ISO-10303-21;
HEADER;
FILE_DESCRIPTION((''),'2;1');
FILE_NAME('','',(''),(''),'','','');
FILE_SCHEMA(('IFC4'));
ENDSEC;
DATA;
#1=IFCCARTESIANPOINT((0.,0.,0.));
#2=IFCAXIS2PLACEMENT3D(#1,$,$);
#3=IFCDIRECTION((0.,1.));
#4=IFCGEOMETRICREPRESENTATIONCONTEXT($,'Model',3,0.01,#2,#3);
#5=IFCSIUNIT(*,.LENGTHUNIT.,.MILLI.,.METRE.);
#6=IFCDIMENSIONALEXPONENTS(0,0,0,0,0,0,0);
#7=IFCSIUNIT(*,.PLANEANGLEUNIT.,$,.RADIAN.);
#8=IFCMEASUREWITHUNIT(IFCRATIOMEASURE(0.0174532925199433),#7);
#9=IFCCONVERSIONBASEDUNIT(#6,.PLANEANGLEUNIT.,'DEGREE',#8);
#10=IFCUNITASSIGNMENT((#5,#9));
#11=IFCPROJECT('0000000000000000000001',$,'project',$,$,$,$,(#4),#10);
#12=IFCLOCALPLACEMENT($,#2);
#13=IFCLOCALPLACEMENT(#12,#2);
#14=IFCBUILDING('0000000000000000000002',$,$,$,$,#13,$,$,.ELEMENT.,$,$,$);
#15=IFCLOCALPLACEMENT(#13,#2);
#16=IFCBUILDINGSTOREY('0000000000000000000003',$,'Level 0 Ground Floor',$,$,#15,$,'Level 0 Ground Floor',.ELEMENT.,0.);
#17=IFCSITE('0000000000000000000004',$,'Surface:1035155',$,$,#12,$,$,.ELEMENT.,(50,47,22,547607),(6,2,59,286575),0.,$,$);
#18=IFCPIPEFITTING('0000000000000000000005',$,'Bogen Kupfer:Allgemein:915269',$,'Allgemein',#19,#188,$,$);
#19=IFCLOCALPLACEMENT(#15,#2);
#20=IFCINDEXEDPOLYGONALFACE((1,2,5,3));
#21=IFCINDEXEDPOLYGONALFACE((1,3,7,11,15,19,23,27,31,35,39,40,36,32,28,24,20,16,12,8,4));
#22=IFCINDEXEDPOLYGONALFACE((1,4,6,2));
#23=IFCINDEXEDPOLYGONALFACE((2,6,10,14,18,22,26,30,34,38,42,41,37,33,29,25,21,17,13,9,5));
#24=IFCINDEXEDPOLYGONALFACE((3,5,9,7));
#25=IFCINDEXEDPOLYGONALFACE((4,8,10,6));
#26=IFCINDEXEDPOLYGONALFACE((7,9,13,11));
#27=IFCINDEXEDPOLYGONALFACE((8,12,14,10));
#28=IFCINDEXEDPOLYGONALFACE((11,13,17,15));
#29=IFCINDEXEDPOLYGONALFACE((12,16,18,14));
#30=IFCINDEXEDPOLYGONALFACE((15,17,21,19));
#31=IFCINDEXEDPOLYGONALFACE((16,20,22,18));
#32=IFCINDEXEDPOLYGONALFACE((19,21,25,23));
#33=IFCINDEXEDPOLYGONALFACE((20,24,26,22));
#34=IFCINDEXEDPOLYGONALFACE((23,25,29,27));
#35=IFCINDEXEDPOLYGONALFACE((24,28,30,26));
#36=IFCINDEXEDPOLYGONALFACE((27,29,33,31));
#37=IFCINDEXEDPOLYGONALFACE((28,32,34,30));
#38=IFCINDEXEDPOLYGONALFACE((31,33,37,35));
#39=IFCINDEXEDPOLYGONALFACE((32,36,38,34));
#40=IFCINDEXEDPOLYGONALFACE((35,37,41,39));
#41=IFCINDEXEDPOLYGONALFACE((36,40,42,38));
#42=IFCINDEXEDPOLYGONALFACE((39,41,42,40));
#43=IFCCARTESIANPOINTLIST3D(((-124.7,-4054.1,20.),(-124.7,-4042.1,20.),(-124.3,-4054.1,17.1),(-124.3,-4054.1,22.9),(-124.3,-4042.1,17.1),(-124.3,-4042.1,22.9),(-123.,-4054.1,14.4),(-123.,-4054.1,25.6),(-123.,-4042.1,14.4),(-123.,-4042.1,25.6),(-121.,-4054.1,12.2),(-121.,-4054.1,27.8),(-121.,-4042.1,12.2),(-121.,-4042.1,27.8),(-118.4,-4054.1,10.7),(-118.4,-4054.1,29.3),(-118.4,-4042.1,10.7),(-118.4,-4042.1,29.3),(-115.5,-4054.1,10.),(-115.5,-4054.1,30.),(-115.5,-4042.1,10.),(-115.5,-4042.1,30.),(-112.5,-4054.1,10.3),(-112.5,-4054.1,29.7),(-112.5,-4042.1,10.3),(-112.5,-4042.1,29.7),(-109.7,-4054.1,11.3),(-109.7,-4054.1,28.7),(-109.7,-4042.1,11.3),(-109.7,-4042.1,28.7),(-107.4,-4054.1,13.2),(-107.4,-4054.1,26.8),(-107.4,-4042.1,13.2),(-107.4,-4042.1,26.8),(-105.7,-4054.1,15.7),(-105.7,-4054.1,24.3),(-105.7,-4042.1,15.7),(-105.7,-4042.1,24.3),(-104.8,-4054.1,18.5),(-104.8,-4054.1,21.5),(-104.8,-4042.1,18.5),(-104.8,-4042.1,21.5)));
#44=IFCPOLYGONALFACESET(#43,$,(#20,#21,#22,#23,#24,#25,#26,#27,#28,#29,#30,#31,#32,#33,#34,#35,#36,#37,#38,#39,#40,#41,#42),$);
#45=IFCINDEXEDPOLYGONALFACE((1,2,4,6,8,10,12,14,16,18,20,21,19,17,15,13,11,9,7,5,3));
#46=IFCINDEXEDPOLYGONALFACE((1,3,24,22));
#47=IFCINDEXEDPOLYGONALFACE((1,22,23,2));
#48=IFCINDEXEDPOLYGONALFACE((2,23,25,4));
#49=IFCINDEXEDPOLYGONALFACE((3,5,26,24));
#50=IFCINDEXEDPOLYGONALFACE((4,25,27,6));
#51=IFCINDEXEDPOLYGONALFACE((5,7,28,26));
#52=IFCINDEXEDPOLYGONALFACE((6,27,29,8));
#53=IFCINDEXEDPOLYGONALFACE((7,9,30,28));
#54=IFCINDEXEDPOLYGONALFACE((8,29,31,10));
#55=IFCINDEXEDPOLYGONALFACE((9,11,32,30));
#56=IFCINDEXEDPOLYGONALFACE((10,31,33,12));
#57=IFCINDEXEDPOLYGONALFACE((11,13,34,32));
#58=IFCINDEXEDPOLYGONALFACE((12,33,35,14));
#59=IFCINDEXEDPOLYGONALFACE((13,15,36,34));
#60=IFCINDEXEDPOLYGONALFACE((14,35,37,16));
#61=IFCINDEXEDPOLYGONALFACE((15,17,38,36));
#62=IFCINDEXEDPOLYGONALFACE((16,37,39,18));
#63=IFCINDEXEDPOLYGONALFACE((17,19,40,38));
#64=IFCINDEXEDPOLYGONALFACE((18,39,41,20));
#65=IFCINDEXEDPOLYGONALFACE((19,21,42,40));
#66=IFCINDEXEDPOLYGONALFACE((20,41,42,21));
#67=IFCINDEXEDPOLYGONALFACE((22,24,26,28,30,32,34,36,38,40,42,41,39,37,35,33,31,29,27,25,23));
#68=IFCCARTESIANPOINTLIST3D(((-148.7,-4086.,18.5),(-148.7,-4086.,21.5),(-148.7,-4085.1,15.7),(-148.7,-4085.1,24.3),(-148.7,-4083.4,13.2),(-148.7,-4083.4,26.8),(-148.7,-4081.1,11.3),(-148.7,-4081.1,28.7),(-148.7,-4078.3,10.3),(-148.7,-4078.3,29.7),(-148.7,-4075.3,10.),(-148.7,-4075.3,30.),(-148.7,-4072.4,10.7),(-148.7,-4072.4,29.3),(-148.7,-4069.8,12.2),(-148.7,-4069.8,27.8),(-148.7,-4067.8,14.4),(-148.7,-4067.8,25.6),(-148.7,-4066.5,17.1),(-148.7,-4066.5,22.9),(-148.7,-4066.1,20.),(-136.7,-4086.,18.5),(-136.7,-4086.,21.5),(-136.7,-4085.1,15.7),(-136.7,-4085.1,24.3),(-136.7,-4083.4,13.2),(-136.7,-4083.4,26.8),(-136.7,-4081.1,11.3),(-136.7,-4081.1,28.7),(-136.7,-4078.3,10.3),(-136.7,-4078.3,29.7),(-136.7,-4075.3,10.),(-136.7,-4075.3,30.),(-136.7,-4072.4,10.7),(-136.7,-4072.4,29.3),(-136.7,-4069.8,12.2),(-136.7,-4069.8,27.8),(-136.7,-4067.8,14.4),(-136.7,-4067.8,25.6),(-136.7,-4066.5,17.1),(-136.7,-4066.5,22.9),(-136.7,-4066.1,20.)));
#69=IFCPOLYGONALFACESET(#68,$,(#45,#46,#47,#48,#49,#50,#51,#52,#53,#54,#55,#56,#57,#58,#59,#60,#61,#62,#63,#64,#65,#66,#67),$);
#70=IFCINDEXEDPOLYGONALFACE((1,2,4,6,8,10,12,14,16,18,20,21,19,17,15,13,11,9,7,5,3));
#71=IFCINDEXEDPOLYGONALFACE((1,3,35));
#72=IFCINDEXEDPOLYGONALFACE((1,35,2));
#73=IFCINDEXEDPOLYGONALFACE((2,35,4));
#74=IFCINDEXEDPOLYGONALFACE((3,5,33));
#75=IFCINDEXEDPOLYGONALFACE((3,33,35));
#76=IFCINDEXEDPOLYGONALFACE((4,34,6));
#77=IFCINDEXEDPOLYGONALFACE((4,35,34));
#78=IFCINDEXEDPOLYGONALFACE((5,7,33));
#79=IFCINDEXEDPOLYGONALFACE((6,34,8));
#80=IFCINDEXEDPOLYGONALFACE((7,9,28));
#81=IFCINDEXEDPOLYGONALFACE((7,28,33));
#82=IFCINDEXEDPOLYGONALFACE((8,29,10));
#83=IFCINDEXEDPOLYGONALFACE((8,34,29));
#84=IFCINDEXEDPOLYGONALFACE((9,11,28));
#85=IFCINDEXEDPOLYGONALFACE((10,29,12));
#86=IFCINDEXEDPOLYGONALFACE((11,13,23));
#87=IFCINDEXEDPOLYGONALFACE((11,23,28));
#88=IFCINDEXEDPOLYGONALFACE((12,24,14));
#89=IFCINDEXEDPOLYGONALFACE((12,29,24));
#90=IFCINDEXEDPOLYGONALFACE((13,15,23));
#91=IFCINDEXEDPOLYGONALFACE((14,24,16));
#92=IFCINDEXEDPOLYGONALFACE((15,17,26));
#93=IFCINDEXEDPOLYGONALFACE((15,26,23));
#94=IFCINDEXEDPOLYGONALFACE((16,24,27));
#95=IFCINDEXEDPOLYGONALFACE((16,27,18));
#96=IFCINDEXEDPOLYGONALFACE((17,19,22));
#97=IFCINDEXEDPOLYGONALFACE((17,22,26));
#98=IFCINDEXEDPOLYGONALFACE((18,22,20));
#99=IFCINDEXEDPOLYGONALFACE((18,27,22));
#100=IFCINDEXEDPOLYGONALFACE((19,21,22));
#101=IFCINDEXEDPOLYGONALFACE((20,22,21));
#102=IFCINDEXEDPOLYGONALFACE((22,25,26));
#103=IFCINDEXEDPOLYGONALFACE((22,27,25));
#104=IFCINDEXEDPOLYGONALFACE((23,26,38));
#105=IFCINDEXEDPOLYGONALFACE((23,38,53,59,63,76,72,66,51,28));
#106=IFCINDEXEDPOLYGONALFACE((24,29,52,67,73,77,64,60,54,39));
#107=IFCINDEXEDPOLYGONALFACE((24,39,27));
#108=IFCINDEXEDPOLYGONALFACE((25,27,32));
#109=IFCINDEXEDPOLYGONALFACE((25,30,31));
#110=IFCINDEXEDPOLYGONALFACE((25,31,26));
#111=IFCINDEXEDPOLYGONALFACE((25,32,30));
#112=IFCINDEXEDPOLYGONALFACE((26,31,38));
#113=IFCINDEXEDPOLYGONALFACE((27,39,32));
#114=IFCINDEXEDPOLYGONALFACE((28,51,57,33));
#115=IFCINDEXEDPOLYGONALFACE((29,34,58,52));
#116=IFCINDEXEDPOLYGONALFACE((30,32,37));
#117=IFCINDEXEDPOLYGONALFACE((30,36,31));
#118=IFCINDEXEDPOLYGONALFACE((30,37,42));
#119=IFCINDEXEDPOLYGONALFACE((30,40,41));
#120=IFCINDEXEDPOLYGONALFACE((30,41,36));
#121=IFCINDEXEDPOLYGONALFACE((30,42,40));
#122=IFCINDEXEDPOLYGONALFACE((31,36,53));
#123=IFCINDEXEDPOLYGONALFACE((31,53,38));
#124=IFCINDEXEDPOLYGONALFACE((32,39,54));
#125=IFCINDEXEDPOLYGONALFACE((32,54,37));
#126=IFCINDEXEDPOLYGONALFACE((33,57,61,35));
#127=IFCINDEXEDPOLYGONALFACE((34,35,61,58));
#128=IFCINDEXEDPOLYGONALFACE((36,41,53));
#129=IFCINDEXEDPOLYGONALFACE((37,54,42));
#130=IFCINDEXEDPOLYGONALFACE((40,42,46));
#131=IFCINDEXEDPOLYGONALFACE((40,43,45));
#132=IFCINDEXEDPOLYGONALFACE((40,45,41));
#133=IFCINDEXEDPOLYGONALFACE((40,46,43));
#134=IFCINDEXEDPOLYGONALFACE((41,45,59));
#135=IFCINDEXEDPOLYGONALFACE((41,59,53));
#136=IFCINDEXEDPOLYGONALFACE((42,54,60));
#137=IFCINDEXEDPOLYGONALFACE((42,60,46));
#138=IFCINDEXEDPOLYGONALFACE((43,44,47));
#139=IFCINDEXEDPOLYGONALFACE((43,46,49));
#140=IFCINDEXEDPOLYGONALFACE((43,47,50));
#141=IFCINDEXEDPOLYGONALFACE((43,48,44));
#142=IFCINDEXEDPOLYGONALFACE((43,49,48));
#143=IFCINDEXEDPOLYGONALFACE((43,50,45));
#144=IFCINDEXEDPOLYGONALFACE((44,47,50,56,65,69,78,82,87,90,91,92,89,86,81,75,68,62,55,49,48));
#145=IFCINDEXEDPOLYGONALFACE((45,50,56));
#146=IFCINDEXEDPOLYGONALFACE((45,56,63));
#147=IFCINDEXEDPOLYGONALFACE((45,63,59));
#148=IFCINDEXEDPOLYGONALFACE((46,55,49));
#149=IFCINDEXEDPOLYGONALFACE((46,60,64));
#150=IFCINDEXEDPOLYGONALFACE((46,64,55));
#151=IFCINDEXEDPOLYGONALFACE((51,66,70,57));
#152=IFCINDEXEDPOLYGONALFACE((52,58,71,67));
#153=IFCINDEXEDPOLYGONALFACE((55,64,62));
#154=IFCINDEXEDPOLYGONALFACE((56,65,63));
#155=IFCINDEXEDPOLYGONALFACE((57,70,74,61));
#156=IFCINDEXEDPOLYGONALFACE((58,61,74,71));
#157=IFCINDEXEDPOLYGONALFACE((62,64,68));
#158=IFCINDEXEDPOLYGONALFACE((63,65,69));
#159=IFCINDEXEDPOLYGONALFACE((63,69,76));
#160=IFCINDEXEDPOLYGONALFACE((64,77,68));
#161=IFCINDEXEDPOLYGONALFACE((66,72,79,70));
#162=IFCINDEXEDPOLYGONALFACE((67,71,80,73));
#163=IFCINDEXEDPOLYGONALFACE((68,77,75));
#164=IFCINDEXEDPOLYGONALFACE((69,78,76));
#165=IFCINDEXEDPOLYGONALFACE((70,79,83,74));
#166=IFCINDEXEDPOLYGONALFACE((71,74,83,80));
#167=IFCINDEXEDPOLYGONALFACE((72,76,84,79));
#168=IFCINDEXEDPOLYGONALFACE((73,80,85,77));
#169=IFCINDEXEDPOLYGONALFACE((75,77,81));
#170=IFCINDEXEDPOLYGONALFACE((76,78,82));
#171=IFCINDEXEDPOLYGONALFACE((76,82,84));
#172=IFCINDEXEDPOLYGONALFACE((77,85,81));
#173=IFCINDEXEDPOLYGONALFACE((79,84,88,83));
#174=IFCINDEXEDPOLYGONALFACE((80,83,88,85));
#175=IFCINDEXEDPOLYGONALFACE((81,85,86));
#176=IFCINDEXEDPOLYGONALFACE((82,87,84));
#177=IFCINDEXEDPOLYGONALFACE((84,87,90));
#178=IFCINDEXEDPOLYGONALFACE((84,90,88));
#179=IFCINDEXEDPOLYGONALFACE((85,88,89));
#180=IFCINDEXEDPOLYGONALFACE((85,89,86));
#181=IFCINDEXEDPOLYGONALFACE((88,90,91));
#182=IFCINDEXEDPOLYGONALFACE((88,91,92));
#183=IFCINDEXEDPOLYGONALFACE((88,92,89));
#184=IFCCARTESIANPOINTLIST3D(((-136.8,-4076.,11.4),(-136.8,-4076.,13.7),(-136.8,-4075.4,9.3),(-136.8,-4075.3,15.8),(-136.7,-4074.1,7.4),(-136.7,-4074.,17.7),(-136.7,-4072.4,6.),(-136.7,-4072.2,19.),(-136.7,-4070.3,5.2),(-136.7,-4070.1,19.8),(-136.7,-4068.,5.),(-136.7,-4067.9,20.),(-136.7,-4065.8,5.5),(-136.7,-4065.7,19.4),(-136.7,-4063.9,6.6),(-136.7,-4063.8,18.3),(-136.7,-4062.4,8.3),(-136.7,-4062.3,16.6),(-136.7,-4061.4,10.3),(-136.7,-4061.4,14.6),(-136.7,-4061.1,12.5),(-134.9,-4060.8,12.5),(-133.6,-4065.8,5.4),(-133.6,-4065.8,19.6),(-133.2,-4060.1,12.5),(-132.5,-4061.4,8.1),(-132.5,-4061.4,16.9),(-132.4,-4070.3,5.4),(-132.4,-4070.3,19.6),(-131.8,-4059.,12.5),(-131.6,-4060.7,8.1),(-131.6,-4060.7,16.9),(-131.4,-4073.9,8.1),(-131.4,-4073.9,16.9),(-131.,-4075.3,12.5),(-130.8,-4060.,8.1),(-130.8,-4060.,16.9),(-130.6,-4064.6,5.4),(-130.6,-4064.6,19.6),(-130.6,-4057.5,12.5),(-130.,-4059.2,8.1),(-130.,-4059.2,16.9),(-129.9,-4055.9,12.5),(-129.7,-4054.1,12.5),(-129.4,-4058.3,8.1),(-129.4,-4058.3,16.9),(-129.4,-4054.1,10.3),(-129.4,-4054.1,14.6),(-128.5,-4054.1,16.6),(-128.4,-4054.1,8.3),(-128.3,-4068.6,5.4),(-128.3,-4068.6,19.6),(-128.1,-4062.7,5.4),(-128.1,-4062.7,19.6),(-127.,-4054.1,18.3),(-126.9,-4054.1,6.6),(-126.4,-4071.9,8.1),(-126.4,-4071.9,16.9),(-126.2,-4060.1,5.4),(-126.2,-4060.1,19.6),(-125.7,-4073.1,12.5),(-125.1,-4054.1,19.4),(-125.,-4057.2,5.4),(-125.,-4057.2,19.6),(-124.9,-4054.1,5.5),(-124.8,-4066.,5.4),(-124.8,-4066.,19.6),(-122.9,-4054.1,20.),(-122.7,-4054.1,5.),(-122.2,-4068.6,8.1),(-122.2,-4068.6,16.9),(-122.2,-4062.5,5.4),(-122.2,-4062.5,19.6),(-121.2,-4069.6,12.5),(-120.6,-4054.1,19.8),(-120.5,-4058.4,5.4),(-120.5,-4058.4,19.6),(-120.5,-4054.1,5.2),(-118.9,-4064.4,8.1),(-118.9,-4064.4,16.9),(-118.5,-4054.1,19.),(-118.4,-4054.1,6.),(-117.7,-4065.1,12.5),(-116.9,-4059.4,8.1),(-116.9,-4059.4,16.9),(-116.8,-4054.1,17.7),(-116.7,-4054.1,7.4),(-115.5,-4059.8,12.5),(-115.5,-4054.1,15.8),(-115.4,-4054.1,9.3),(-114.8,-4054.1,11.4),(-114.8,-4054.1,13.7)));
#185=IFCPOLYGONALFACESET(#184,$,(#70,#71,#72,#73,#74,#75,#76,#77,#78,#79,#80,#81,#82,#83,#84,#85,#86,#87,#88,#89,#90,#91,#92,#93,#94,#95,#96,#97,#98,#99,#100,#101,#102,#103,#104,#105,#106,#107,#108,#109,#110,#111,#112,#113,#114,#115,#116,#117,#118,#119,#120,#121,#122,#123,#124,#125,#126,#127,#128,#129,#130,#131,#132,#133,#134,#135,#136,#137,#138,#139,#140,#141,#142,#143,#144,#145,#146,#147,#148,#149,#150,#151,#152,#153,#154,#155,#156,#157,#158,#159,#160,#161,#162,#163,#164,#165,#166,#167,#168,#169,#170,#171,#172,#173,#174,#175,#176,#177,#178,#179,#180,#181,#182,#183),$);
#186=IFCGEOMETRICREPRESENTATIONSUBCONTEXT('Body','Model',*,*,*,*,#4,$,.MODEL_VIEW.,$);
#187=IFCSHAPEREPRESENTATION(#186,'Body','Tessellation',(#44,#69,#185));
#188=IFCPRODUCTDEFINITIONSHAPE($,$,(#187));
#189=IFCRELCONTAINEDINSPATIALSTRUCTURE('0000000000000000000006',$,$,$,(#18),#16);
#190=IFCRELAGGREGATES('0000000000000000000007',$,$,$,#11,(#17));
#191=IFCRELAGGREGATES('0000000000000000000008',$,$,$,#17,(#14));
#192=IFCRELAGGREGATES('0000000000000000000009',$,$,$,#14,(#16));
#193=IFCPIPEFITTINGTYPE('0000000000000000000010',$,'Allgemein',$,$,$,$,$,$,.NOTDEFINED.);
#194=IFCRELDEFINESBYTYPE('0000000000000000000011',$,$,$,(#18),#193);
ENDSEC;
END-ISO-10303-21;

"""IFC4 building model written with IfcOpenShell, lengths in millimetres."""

from ifc_helpers import new_model, entity, si_unit, converted_unit, direction, frame, frame_2d, origin, place, context, subcontext, project, spatial, circle, extrude, source, transform, mapped, type_object, type_shapes, element, save


model = new_model("IFC4")

# Units and contexts
model_context = context("Model", 3, precision=0.01, world=origin(), true_north=direction((0.0, 1.0)))
body_context = subcontext(model_context, "Body", "Model", "MODEL_VIEW")
ifc_project = project(units=[si_unit("LENGTHUNIT", "METRE", prefix="MILLI"), converted_unit("PLANEANGLEUNIT", "DEGREE", entity("IfcRatioMeasure", 0.0174532925199433), si_unit("PLANEANGLEUNIT", "RADIAN"), dimensions=[0, 0, 0, 0, 0, 0, 0])], contexts=[model_context])

# Site, building, storey
site_placement = place(None, origin())
site = spatial("IfcSite", under=ifc_project, at=site_placement, Name="Surface:1035155", CompositionType="ELEMENT", RefLatitude=(50, 47, 22, 547607), RefLongitude=(6, 2, 59, 286575), RefElevation=0.0)
building_placement = place(site_placement, origin())
building = spatial("IfcBuilding", under=site, at=building_placement, CompositionType="ELEMENT")
storey_placement = place(building_placement, origin())
storey = spatial("IfcBuildingStorey", under=building, at=storey_placement, Name="Level 0 Ground Floor", LongName="Level 0 Ground Floor", CompositionType="ELEMENT", Elevation=0.0)

# Shared definitions
pipe_fitting_type = type_object("IfcPipeFittingType", Name="Allgemein", PredefinedType="NOTDEFINED")
ifc_direction = entity("IfcDirection", [0.0, 0.0, -1.0])
trimmed_curve = entity("IfcTrimmedCurve", entity("IfcCircle", entity("IfcAxis2Placement2D", entity("IfcCartesianPoint", [-14.5, 0.0]), entity("IfcDirection", [0.0, 1.0])), 14.5), [entity("IfcParameterValue", 270.0)], [entity("IfcParameterValue", 0.0)], True, "PARAMETER")
shared_shape_1 = source(origin(), body_context, "Body", "SolidModel", [
    extrude(circle(Radius=10.0, at=frame_2d((0.0, 0.0), x_axis=(1.0, 0.0))), frame((0.0, 22.0, 0.0), z_axis=(0.0, 1.0, 0.0), x_axis=(-1.0, 0.0, 0.0)), (0.0, 0.0, 1.0), 12.0),
    extrude(circle(Radius=10.0, at=frame_2d((0.0, 0.0), x_axis=(1.0, 0.0))), frame((-34.0, 0.0, 0.0), z_axis=(1.0, 0.0, 0.0), x_axis=(0.0, 1.0, 0.0)), (0.0, 0.0, 1.0), 12.0),
    entity("IfcSurfaceCurveSweptAreaSolid", entity("IfcCircleProfileDef", "AREA", None, entity("IfcAxis2Placement2D", entity("IfcCartesianPoint", [0.0, 7.5]), entity("IfcDirection", [1.0, 0.0])), 7.5), entity("IfcAxis2Placement3D", entity("IfcCartesianPoint", [-7.5, 22.0, 0.0]), ifc_direction, entity("IfcDirection", [1.0, 0.0, 0.0])), trimmed_curve, 0.0, 90.0, entity("IfcSurfaceOfLinearExtrusion", entity("IfcArbitraryOpenProfileDef", "CURVE", None, trimmed_curve), entity("IfcAxis2Placement3D", entity("IfcCartesianPoint", [0.0, 0.0, -304.8])), ifc_direction, 1.0)),
])
type_shapes(pipe_fitting_type, [shared_shape_1])

# Pipe fitting
for number, where, name in (
    (1, (-114.7, -4076.1, 20.0), "Bogen Kupfer:Allgemein:915269"),
):
    element("IfcPipeFitting", number, at=place(storey_placement, frame(where)), inside=storey, type_object=pipe_fitting_type, Name=name, ObjectType="Allgemein", context=body_context, shape_type="MappedRepresentation", body=[
        mapped(shared_shape_1, transform((0.0, 0.0, 0.0), scale=1.0)),
    ])

save(model, "model.ifc")
